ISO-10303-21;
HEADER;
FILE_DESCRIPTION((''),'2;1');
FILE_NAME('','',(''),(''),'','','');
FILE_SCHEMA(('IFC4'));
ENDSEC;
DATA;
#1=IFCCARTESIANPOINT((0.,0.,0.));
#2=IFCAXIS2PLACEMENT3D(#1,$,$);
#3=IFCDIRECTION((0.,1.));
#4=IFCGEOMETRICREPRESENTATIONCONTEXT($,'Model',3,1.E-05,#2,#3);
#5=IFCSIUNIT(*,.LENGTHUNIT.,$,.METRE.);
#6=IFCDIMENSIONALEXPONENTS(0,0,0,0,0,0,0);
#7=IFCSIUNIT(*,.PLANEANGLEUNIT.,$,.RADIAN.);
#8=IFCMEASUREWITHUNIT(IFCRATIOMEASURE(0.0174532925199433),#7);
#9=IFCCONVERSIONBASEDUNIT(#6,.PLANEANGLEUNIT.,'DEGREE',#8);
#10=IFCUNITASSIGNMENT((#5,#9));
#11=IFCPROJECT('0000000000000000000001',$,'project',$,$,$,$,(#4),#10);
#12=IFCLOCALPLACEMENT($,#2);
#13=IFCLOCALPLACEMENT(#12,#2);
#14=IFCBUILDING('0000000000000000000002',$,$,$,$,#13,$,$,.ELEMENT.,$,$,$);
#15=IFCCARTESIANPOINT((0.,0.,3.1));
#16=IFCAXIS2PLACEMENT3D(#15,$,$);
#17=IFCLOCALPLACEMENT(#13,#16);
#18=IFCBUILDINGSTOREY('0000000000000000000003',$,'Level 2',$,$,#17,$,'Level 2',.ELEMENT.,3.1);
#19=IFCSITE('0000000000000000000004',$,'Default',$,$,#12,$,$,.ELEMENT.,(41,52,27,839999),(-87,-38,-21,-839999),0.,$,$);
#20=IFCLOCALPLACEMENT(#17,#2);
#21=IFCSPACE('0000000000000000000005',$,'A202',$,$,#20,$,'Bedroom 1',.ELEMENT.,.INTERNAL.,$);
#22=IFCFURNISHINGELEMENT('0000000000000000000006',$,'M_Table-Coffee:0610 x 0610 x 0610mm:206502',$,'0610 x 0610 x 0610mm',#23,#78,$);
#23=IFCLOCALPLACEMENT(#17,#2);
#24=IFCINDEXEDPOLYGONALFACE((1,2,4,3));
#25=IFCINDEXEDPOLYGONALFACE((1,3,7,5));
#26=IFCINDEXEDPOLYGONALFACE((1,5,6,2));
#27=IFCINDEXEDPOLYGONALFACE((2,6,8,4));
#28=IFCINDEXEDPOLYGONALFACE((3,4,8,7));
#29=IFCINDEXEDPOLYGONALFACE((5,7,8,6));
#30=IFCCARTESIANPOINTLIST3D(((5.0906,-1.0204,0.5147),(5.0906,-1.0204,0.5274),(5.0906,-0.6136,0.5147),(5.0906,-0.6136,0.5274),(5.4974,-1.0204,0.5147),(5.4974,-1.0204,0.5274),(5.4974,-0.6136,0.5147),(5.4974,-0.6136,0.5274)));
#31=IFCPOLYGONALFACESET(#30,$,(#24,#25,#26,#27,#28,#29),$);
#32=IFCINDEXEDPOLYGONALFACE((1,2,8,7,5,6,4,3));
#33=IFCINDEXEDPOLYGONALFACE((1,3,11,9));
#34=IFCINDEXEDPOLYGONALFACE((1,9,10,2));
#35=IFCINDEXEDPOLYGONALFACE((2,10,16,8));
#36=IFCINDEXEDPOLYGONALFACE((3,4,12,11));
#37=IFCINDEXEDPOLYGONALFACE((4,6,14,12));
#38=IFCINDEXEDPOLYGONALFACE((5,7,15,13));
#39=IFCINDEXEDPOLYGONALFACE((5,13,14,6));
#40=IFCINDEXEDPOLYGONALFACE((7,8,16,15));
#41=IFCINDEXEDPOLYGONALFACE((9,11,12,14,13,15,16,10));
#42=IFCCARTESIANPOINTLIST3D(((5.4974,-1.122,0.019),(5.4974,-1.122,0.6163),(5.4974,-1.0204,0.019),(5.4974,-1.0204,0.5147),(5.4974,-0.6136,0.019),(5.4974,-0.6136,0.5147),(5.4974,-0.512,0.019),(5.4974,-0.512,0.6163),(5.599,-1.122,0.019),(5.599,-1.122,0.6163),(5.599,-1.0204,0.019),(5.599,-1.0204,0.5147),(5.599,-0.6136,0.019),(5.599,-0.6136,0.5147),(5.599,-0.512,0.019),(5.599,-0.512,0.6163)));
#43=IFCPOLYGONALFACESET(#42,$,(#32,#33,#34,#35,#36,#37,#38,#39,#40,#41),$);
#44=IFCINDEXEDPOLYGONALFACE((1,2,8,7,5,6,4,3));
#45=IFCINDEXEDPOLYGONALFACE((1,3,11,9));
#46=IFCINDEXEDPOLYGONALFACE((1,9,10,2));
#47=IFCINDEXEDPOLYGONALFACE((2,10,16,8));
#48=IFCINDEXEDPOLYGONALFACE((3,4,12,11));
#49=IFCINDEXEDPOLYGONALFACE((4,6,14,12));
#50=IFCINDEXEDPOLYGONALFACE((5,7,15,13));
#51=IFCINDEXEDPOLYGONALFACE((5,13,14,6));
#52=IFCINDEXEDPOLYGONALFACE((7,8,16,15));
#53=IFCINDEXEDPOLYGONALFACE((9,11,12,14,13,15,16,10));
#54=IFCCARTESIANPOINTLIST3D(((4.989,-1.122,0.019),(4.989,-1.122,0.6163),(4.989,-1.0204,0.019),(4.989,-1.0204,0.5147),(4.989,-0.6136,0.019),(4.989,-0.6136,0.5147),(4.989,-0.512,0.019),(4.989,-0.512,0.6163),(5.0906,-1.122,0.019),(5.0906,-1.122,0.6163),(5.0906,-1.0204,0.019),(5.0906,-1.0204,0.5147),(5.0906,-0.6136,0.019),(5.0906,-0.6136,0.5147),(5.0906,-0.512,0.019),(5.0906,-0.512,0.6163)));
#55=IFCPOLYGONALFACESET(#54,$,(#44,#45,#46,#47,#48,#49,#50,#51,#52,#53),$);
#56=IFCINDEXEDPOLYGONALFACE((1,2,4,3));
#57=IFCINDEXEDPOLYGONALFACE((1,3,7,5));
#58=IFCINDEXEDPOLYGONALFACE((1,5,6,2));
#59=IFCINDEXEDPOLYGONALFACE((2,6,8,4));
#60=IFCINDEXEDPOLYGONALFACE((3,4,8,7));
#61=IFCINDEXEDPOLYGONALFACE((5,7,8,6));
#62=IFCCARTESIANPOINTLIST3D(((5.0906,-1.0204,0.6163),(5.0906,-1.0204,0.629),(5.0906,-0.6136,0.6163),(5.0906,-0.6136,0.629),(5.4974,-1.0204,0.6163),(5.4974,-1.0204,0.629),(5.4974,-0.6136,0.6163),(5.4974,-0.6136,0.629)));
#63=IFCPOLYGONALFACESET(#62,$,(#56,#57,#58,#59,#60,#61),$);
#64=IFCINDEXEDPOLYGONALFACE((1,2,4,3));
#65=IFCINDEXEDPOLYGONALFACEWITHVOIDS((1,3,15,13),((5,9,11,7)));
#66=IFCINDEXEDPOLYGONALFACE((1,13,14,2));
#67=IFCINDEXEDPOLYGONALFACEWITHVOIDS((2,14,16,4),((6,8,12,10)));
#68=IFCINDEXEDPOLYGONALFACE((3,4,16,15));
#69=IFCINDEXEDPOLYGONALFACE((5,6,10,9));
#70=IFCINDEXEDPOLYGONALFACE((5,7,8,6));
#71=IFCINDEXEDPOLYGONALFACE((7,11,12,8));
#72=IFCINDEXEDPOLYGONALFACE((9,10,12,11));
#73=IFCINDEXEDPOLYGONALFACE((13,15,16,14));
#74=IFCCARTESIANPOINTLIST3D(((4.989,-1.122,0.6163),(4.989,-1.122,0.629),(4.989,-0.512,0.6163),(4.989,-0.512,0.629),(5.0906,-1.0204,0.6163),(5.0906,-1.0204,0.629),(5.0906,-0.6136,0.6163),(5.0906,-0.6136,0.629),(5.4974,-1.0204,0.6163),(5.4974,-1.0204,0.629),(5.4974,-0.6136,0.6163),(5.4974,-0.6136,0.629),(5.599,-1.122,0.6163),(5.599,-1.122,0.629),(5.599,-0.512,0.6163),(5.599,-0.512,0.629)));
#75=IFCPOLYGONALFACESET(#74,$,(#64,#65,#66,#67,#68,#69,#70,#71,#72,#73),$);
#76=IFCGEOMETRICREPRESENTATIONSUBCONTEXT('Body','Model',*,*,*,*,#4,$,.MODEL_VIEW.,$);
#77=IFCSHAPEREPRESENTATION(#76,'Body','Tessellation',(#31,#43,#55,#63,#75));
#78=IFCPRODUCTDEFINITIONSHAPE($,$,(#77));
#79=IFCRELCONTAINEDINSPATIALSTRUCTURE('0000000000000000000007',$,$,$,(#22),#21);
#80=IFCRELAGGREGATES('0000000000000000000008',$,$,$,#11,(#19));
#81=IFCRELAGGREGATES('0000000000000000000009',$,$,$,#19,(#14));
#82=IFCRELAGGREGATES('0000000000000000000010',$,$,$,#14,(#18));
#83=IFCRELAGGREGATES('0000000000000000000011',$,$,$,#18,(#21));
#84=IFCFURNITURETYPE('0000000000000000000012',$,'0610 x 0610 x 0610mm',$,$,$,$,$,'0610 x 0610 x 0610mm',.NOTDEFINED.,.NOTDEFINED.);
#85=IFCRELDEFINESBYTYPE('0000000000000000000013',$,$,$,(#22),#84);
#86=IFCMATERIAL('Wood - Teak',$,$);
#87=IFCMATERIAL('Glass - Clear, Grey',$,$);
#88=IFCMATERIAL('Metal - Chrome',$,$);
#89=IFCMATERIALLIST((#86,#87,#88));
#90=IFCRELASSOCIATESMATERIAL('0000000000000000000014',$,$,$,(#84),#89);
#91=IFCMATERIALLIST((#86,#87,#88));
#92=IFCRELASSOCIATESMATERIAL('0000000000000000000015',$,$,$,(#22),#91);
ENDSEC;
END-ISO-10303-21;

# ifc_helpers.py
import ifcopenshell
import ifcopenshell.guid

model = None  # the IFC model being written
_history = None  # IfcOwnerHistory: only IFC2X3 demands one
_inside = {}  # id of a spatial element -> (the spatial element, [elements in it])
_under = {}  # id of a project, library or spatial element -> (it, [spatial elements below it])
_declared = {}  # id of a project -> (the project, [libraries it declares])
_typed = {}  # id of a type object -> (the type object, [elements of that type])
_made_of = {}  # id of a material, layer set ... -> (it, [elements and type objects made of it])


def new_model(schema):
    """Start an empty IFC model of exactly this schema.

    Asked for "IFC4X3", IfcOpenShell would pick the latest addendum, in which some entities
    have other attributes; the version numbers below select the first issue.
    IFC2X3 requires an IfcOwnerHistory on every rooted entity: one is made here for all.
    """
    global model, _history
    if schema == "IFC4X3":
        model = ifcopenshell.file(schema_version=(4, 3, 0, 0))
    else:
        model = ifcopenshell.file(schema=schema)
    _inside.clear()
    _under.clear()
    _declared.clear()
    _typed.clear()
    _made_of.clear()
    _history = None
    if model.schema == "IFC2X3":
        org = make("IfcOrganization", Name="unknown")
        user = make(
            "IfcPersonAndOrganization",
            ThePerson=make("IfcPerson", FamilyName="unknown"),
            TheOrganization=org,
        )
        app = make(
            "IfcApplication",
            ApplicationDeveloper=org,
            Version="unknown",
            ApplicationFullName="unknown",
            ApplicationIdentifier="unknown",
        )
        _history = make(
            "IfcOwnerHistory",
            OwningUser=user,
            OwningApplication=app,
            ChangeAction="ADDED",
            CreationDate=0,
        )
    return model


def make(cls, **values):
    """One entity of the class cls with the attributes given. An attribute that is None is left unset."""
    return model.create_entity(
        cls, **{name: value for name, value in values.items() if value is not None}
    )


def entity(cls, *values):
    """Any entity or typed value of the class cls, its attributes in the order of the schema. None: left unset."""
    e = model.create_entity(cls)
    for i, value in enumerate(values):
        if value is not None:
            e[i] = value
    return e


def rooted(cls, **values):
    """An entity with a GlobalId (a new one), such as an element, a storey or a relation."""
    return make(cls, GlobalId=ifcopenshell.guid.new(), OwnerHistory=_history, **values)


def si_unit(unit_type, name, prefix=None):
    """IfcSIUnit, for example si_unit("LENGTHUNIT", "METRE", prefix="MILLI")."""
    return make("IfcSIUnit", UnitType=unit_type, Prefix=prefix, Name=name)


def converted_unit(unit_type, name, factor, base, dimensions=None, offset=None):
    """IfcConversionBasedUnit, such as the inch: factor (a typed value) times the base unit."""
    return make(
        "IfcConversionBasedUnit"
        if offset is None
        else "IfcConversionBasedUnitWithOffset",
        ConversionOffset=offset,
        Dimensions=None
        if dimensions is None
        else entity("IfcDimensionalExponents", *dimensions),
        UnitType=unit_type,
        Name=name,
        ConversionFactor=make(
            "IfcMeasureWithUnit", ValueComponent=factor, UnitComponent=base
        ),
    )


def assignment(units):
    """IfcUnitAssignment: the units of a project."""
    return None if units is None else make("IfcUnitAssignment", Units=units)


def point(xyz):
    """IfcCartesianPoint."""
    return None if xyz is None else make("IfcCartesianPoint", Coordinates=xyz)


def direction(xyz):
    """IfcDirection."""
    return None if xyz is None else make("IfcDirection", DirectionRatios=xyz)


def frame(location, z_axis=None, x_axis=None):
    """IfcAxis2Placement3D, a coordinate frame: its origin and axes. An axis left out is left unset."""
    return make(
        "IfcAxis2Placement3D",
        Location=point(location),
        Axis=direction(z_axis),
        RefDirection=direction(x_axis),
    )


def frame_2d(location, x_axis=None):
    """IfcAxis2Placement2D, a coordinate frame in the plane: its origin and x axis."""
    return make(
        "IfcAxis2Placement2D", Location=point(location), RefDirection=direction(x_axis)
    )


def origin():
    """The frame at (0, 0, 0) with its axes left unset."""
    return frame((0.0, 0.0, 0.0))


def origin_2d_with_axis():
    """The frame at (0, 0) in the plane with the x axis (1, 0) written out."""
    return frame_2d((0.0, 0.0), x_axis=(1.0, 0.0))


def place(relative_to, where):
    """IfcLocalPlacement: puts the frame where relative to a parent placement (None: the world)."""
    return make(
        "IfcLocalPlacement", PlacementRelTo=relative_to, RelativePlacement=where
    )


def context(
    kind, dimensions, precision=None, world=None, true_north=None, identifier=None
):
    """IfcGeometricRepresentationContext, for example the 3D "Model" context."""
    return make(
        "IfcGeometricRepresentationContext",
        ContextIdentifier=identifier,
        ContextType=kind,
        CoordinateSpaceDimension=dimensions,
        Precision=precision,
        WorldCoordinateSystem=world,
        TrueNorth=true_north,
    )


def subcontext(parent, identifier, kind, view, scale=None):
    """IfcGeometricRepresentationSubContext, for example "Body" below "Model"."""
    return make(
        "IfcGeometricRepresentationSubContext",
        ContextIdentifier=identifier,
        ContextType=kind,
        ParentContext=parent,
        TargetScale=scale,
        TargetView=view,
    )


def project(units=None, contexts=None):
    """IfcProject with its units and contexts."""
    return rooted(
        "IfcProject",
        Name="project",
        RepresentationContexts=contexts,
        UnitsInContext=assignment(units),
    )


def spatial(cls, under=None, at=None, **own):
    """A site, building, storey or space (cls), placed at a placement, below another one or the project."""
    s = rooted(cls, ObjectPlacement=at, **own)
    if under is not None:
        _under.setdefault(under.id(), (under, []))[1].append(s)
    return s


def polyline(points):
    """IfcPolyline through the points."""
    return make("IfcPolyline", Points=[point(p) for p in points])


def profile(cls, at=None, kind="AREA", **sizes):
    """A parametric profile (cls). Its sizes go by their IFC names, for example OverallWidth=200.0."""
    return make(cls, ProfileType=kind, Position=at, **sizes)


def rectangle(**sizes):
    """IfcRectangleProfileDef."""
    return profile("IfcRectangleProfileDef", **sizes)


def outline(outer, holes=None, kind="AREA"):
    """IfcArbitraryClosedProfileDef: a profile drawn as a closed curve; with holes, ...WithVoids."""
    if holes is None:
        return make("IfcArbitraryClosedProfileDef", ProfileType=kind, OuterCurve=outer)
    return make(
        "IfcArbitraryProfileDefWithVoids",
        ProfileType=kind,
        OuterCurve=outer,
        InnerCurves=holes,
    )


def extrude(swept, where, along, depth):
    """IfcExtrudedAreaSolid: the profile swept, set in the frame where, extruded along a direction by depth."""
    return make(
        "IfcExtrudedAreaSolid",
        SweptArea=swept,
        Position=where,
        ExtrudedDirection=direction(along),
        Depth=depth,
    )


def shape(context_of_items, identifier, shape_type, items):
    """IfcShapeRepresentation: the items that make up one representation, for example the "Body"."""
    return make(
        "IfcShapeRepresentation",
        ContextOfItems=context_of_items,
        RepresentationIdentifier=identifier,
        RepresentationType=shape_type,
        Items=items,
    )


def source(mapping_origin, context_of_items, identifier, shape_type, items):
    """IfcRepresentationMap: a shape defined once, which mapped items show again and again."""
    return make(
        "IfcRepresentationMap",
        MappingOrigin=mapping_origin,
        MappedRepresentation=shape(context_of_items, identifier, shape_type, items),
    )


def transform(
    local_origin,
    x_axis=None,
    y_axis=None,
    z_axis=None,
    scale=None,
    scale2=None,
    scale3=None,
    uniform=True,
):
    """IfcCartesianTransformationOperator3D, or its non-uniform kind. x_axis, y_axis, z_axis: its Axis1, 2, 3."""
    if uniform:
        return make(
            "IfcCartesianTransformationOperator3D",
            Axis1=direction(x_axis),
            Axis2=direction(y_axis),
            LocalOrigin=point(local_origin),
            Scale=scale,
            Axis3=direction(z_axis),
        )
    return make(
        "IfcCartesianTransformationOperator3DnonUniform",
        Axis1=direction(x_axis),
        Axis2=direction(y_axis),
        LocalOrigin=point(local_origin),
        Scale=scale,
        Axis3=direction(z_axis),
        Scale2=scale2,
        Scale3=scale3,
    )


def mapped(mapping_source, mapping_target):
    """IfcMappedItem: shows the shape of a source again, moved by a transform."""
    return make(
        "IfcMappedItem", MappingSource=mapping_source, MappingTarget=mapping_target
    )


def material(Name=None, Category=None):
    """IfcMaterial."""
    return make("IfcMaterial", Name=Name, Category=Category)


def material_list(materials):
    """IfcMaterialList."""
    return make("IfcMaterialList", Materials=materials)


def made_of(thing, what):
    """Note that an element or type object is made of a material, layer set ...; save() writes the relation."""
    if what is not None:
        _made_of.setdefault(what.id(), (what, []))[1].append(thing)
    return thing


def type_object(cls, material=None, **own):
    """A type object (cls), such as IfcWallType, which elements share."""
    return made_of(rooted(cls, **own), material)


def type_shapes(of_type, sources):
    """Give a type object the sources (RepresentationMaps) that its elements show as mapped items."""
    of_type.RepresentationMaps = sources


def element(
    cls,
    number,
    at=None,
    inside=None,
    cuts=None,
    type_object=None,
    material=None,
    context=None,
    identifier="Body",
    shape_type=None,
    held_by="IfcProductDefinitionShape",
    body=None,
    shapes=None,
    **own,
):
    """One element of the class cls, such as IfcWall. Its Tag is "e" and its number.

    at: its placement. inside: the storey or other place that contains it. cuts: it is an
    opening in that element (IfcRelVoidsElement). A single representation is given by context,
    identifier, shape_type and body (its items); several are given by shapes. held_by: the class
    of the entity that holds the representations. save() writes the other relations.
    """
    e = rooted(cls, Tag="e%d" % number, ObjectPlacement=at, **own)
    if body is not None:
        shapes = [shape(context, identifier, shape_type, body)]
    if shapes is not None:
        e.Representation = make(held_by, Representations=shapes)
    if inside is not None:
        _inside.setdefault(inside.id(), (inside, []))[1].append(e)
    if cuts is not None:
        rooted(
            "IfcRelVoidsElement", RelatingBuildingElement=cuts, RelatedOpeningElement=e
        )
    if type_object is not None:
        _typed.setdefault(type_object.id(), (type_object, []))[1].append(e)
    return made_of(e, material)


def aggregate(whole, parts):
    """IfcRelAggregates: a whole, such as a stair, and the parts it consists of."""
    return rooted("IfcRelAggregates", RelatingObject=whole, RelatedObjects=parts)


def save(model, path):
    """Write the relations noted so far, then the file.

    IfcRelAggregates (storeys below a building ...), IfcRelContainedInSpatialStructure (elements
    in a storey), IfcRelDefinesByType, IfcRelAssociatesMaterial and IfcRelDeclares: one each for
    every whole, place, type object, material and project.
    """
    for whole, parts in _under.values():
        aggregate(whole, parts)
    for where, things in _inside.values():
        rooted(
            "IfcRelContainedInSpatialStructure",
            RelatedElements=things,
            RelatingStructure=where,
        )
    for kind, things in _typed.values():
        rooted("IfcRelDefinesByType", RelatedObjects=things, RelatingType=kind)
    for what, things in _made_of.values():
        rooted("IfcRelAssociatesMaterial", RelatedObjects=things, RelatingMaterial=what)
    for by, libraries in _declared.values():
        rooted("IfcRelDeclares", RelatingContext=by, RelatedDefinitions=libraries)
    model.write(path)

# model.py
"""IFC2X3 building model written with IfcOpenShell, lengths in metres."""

from ifc_helpers import new_model, entity, si_unit, converted_unit, direction, frame, origin, origin_2d_with_axis, place, context, subcontext, project, spatial, polyline, rectangle, outline, extrude, source, transform, mapped, material, material_list, type_object, type_shapes, element, save


model = new_model("IFC2X3")

# Units and contexts
model_context = context("Model", 3, precision=1e-05, world=origin(), true_north=direction((0.0, 1.0)))
body_context = subcontext(model_context, "Body", "Model", "MODEL_VIEW")
ifc_project = project(units=[si_unit("LENGTHUNIT", "METRE"), converted_unit("PLANEANGLEUNIT", "DEGREE", entity("IfcRatioMeasure", 0.0174532925199433), si_unit("PLANEANGLEUNIT", "RADIAN"), dimensions=[0, 0, 0, 0, 0, 0, 0])], contexts=[model_context])

# Site, building, storey
site_placement = place(None, origin())
site = spatial("IfcSite", under=ifc_project, at=site_placement, Name="Default", CompositionType="ELEMENT", RefLatitude=(41, 52, 27, 839999), RefLongitude=(-87, -38, -21, -839999), RefElevation=0.0)
building_placement = place(site_placement, origin())
building = spatial("IfcBuilding", under=site, at=building_placement, CompositionType="ELEMENT")
storey_placement = place(building_placement, frame((0.0, 0.0, 3.1)))
storey = spatial("IfcBuildingStorey", under=building, at=storey_placement, Name="Level 2", LongName="Level 2", CompositionType="ELEMENT", Elevation=3.1)

# Shared definitions
ifc_material_1 = material(Name="Wood - Teak")
ifc_material_2 = material(Name="Glass - Clear, Grey")
ifc_material_3 = material(Name="Metal - Chrome")
ifc_material_list_1 = material_list([ifc_material_1, ifc_material_2, ifc_material_3])
furniture_type_1 = type_object("IfcFurnitureType", Name="0610 x 0610 x 0610mm", ElementType="0610 x 0610 x 0610mm", AssemblyPlace="NOTDEFINED", material=ifc_material_list_1)
shared_shape_1 = source(origin(), body_context, "Body", "SweptSolid", [
    extrude(rectangle(XDim=0.4068, YDim=0.4068, at=origin_2d_with_axis()), frame((0.0183, 0.0952, 0.4957), z_axis=(0.0, 0.0, 1.0), x_axis=(-1.0, 0.0, 0.0)), (0.0, 0.0, 1.0), 0.0127),
    extrude(outline(polyline([(-0.2732, -0.305), (0.324, -0.305), (0.324, 0.305), (-0.2732, 0.305), (-0.2732, 0.2034), (0.2225, 0.2034), (0.2225, -0.2034), (-0.2732, -0.2034), (-0.2732, -0.305)])), frame((0.2217, 0.0952, 0.2732), z_axis=(1.0, 0.0, 0.0), x_axis=(0.0, 0.0, 1.0)), (0.0, 0.0, 1.0), 0.1016),
    extrude(outline(polyline([(-0.305, -0.3241), (0.305, -0.3241), (0.305, 0.2733), (0.2034, 0.2733), (0.2034, -0.2224), (-0.2034, -0.2224), (-0.2034, 0.2733), (-0.305, 0.2733), (-0.305, -0.3241)])), frame((-0.2867, 0.0952, 0.2733), z_axis=(1.0, 0.0, 0.0), x_axis=(0.0, -1.0, 0.0)), (0.0, 0.0, 1.0), 0.1016),
    extrude(rectangle(XDim=0.4068, YDim=0.4068, at=origin_2d_with_axis()), frame((0.0183, 0.0952, 0.5973), z_axis=(0.0, 0.0, 1.0), x_axis=(-1.0, 0.0, 0.0)), (0.0, 0.0, 1.0), 0.0127),
    extrude(outline(polyline([(-0.305, -0.305), (0.305, -0.305), (0.305, 0.305), (-0.305, 0.305), (-0.305, -0.305)]), holes=[polyline([(-0.2034, -0.2034), (-0.2034, 0.2034), (0.2034, 0.2034), (0.2034, -0.2034), (-0.2034, -0.2034)])]), frame((0.0183, 0.0952, 0.5973), z_axis=(0.0, 0.0, 1.0), x_axis=(-1.0, 0.0, 0.0)), (0.0, 0.0, 1.0), 0.0127),
])
type_shapes(furniture_type_1, [shared_shape_1])

# Shared definitions
space_1_placement = place(storey_placement, origin())
space_1 = spatial("IfcSpace", under=storey, at=space_1_placement, Name="A202", LongName="Bedroom 1", CompositionType="ELEMENT", InteriorOrExteriorSpace="INTERNAL")

# Furnishing element
ifc_material_list_2 = material_list([ifc_material_1, ifc_material_2, ifc_material_3])
furnishing_1_placement = place(space_1_placement, frame((5.2757, -0.9122, 0.019)))
element("IfcFurnishingElement", 1, at=furnishing_1_placement, inside=space_1, type_object=furniture_type_1, material=ifc_material_list_2, Name="M_Table-Coffee:0610 x 0610 x 0610mm:206502", ObjectType="0610 x 0610 x 0610mm", context=body_context, shape_type="MappedRepresentation", body=[
    mapped(shared_shape_1, transform((0.0, 0.0, 0.0), scale=1.0)),
])

save(model, "model.ifc")
